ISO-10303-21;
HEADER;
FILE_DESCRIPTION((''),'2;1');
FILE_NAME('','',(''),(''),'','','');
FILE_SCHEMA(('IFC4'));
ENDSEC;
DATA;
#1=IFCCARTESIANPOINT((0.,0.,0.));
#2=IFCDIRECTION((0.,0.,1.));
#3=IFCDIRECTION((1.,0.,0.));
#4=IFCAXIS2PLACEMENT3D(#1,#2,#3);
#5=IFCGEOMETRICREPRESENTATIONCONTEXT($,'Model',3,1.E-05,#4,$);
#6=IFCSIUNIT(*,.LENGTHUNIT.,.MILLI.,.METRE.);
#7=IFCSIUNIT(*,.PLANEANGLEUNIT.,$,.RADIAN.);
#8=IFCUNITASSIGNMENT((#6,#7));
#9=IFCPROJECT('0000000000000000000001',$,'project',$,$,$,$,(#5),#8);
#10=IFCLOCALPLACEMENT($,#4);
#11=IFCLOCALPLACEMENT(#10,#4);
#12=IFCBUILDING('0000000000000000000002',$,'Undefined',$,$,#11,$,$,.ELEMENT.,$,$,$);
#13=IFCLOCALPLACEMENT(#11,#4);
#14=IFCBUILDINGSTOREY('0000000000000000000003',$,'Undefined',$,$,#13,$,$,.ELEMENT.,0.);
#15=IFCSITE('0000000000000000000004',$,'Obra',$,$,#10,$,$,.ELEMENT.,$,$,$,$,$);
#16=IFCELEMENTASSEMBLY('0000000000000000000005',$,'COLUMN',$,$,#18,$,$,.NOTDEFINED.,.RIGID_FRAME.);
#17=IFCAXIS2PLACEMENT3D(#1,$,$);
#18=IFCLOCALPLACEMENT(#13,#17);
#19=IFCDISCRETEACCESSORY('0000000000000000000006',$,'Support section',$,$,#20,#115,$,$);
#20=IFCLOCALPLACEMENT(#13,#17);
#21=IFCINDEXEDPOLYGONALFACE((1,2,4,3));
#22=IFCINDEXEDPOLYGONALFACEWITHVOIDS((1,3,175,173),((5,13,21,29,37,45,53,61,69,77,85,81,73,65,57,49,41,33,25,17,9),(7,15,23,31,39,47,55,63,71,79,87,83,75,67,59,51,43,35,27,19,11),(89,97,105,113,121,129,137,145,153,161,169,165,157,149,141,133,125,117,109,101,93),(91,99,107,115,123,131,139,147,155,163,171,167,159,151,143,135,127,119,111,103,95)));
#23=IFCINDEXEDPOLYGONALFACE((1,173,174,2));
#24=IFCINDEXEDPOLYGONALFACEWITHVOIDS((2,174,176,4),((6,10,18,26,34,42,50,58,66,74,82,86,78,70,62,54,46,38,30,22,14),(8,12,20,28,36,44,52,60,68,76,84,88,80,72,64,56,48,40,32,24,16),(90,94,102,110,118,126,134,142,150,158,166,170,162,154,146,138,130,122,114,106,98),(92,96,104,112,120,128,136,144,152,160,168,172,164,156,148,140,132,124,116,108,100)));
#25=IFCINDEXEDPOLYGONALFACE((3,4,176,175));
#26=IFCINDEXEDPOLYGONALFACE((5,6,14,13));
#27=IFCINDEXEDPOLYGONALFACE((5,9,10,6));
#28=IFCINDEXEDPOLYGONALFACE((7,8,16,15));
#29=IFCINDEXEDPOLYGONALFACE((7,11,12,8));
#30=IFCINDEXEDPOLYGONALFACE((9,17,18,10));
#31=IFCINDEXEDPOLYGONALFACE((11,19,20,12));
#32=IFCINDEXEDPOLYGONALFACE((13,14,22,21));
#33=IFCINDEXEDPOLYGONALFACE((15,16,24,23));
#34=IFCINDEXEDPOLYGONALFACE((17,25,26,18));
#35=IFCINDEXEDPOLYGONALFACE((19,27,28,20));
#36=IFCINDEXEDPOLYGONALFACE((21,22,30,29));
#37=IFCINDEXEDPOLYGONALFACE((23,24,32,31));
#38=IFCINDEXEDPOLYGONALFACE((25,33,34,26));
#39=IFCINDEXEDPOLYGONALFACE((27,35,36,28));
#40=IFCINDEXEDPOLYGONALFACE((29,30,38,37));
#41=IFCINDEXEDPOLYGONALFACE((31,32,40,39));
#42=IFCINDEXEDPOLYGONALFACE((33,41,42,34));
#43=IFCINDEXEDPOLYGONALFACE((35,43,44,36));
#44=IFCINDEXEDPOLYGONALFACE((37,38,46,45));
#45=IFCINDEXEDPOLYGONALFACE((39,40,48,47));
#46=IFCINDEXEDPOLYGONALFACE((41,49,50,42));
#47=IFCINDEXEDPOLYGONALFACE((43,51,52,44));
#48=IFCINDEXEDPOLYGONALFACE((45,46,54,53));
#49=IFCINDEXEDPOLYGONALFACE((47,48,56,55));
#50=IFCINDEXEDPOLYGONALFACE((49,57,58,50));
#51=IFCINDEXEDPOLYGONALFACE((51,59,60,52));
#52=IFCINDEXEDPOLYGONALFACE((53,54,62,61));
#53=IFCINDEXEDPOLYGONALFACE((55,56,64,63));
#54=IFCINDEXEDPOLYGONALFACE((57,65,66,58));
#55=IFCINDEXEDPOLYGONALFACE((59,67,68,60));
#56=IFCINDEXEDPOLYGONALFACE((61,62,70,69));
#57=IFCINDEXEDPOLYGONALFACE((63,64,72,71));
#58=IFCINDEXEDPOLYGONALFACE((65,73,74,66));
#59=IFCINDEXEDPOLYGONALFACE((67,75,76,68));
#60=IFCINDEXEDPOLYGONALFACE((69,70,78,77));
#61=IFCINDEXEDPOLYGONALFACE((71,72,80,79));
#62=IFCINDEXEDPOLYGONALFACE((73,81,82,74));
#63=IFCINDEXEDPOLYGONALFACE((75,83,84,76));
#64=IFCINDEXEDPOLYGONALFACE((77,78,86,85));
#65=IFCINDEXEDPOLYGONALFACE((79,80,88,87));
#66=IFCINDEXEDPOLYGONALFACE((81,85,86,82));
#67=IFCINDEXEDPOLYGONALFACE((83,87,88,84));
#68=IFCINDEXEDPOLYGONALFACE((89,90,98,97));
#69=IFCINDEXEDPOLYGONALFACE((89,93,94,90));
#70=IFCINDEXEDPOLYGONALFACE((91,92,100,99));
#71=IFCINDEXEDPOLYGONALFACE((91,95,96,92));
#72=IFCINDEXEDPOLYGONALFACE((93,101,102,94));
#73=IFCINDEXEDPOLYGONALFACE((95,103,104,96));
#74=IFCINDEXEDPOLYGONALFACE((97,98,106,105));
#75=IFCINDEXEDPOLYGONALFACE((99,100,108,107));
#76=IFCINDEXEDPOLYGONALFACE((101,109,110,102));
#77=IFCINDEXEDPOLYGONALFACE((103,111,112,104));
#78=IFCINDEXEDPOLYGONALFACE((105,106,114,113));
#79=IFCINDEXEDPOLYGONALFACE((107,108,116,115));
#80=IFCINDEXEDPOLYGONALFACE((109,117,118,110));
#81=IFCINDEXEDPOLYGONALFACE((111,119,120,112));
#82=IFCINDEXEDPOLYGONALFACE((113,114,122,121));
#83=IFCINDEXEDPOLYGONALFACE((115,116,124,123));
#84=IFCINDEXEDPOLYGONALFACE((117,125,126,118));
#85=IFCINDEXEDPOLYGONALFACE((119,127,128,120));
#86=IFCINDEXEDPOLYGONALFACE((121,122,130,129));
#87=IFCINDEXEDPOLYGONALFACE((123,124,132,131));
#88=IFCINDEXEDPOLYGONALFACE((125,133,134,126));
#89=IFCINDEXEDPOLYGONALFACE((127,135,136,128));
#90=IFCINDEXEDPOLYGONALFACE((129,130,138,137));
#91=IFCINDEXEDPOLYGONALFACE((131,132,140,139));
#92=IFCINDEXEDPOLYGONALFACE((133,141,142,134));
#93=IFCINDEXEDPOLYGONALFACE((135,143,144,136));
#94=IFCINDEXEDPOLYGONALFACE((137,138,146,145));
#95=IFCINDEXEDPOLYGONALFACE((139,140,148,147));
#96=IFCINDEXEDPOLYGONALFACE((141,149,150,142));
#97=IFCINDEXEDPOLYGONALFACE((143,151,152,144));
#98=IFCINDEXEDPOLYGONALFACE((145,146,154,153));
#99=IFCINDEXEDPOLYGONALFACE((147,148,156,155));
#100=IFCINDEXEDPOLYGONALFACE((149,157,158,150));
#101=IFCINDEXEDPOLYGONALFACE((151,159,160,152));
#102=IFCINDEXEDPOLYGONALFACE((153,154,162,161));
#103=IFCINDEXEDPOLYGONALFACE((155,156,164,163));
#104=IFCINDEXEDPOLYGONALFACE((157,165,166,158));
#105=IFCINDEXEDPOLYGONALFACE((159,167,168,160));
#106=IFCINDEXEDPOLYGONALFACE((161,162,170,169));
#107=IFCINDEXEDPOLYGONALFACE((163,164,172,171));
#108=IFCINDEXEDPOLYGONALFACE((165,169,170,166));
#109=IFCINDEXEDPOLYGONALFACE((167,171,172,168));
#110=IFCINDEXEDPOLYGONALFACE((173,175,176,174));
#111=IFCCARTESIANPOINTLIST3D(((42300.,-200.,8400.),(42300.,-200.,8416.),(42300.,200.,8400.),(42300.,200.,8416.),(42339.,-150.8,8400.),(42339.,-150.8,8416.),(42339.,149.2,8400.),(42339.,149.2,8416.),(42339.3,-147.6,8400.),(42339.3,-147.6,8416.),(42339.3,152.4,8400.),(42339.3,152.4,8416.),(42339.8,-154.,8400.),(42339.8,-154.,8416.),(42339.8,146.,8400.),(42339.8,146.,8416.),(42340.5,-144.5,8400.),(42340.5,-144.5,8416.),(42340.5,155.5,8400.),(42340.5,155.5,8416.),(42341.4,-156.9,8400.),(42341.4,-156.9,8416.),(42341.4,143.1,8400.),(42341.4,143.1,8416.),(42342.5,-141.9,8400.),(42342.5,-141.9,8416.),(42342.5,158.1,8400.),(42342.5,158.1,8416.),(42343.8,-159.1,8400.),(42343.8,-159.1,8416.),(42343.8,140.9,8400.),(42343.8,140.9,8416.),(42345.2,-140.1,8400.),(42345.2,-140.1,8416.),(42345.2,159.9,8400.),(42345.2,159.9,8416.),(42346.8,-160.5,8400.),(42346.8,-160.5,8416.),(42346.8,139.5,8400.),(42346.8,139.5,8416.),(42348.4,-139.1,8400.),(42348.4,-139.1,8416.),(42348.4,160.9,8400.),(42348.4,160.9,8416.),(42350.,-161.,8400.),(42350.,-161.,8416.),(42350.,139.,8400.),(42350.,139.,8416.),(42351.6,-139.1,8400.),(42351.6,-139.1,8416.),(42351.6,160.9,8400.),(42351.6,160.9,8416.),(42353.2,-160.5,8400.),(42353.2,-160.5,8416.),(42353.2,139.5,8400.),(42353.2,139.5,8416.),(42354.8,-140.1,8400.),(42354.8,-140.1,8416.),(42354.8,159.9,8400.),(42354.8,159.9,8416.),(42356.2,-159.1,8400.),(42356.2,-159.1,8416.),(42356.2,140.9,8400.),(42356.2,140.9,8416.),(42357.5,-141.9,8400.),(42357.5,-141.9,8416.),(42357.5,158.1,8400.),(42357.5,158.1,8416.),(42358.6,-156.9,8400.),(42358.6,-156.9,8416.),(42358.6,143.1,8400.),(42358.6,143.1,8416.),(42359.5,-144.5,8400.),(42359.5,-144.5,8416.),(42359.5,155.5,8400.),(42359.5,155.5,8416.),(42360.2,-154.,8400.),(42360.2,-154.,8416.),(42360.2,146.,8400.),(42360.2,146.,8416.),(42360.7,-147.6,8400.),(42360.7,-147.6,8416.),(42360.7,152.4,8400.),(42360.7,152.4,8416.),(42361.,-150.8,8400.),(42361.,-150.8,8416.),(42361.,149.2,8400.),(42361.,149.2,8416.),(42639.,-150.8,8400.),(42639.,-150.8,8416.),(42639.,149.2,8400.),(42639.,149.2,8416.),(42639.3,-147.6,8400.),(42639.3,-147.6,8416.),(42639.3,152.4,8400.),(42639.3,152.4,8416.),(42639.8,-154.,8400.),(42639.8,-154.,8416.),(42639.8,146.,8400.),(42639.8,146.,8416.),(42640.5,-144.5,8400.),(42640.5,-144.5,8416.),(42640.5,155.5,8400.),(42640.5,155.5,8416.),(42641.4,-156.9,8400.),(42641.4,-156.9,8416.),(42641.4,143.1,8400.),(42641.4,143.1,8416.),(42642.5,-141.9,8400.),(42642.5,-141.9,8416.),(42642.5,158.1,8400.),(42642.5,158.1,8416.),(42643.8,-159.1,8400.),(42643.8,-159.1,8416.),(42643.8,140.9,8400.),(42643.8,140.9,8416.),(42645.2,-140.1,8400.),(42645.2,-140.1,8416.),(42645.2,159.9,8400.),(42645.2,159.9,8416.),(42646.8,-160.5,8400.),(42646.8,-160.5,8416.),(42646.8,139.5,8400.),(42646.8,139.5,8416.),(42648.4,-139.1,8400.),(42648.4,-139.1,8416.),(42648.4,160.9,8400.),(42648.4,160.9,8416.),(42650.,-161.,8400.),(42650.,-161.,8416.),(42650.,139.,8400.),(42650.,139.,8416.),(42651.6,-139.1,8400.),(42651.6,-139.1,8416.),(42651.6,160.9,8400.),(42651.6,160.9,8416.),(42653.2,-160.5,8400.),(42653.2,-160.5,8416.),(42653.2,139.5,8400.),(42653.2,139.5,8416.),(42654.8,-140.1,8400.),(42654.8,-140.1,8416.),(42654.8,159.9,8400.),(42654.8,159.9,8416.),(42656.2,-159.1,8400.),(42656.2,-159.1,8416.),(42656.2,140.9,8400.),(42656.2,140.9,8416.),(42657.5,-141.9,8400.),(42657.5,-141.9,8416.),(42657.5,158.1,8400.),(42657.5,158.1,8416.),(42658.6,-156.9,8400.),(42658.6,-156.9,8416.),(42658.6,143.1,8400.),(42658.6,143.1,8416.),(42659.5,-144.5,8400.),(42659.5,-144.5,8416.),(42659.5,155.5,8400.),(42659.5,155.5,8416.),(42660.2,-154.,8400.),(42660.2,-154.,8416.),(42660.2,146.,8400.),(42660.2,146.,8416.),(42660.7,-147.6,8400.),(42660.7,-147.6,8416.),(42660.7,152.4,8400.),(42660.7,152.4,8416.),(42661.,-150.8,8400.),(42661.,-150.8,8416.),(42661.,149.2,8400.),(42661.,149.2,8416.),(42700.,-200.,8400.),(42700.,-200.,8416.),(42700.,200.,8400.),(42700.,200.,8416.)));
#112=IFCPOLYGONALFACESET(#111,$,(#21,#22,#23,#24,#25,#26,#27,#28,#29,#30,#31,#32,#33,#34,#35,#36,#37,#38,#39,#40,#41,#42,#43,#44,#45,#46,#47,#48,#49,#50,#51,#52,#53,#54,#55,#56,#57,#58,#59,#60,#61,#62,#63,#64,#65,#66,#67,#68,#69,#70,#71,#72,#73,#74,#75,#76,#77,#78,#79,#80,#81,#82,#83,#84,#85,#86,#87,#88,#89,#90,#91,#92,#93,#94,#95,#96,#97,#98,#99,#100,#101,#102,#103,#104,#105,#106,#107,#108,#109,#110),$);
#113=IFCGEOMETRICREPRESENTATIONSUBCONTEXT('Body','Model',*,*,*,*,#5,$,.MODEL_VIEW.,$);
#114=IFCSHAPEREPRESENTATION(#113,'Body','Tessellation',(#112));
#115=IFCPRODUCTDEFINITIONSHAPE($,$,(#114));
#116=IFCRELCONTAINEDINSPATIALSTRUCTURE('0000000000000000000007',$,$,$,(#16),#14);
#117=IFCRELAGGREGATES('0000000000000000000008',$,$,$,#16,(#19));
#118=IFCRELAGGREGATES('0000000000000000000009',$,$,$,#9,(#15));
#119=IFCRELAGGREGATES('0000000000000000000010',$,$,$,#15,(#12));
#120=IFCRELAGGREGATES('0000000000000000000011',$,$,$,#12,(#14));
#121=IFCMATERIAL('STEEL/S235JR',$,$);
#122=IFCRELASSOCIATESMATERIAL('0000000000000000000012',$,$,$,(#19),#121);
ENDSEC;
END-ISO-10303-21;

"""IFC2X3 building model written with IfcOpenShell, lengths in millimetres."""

from ifc_helpers import new_model, si_unit, frame, origin_with_axes, origin_2d_with_axis, place, context, subcontext, project, spatial, rectangle, circle, extrude, source, transform, mapped, material, element, aggregate, save


model = new_model("IFC2X3")

# Units and contexts
model_context = context("Model", 3, precision=1e-05, world=origin_with_axes())
body_context = subcontext(model_context, "Body", "Model", "MODEL_VIEW")
ifc_project = project(units=[si_unit("LENGTHUNIT", "METRE", prefix="MILLI"), si_unit("PLANEANGLEUNIT", "RADIAN")], contexts=[model_context])

# Site, building, storey
site_placement = place(None, origin_with_axes())
site = spatial("IfcSite", under=ifc_project, at=site_placement, Name="Obra", CompositionType="ELEMENT")
building_placement = place(site_placement, origin_with_axes())
building = spatial("IfcBuilding", under=site, at=building_placement, Name="Undefined", CompositionType="ELEMENT")
storey_placement = place(building_placement, origin_with_axes())
storey = spatial("IfcBuildingStorey", under=building, at=storey_placement, Name="Undefined", CompositionType="ELEMENT", Elevation=0.0)

# Element assembly
assembly_1_placement = place(storey_placement, origin_with_axes())
assembly_1 = element("IfcElementAssembly", 1, at=assembly_1_placement, inside=storey, Name="COLUMN", AssemblyPlace="NOTDEFINED", PredefinedType="RIGID_FRAME")
ifc_material_1 = material(Name="STEEL/S235JR")

# Discrete accessory, opening
discrete_accessory_1_placement = place(assembly_1_placement, frame((42500.0, -200.0, 8408.0), z_axis=(-1.0, 0.0, 0.0), x_axis=(0.0, 1.0, 0.0)))
discrete_accessory_1 = element("IfcDiscreteAccessory", 2, at=discrete_accessory_1_placement, material=ifc_material_1, Name="Support section", context=body_context, shape_type="SweptSolid", body=[
    extrude(rectangle(XDim=16.0, YDim=400.0, at=origin_2d_with_axis()), frame((400.0, 0.0, 0.0), z_axis=(-1.0, 0.0, 0.0), x_axis=(0.0, -1.0, 0.0)), (0.0, 0.0, 1.0), 400.0),
])
shared_shape_1 = source(origin_with_axes(), body_context, "Body", "SweptSolid", [
    extrude(circle(Radius=11.0, at=origin_2d_with_axis()), frame((0.0, -0.1, 0.0), z_axis=(0.0, 1.0, 0.0), x_axis=(1.0, 0.0, 0.0)), (0.0, 0.0, 1.0), 16.2),
])
opening_1_placement = place(assembly_1_placement, frame((42500.0, 152.5, 8416.0), z_axis=(1.0, 0.0, 0.0), x_axis=(0.0, -1.0, 0.0)))
element("IfcOpeningElement", 3, at=opening_1_placement, cuts=discrete_accessory_1, ObjectType="Opening", context=body_context, shape_type="MappedRepresentation", body=[
    mapped(shared_shape_1, transform((2.5, 0.0, 150.0))),
    mapped(shared_shape_1, transform((2.5, 0.0, -150.0))),
    mapped(shared_shape_1, transform((302.5, 0.0, 150.0))),
    mapped(shared_shape_1, transform((302.5, 0.0, -150.0))),
])
aggregate(assembly_1, [discrete_accessory_1])

save(model, "model.ifc")
